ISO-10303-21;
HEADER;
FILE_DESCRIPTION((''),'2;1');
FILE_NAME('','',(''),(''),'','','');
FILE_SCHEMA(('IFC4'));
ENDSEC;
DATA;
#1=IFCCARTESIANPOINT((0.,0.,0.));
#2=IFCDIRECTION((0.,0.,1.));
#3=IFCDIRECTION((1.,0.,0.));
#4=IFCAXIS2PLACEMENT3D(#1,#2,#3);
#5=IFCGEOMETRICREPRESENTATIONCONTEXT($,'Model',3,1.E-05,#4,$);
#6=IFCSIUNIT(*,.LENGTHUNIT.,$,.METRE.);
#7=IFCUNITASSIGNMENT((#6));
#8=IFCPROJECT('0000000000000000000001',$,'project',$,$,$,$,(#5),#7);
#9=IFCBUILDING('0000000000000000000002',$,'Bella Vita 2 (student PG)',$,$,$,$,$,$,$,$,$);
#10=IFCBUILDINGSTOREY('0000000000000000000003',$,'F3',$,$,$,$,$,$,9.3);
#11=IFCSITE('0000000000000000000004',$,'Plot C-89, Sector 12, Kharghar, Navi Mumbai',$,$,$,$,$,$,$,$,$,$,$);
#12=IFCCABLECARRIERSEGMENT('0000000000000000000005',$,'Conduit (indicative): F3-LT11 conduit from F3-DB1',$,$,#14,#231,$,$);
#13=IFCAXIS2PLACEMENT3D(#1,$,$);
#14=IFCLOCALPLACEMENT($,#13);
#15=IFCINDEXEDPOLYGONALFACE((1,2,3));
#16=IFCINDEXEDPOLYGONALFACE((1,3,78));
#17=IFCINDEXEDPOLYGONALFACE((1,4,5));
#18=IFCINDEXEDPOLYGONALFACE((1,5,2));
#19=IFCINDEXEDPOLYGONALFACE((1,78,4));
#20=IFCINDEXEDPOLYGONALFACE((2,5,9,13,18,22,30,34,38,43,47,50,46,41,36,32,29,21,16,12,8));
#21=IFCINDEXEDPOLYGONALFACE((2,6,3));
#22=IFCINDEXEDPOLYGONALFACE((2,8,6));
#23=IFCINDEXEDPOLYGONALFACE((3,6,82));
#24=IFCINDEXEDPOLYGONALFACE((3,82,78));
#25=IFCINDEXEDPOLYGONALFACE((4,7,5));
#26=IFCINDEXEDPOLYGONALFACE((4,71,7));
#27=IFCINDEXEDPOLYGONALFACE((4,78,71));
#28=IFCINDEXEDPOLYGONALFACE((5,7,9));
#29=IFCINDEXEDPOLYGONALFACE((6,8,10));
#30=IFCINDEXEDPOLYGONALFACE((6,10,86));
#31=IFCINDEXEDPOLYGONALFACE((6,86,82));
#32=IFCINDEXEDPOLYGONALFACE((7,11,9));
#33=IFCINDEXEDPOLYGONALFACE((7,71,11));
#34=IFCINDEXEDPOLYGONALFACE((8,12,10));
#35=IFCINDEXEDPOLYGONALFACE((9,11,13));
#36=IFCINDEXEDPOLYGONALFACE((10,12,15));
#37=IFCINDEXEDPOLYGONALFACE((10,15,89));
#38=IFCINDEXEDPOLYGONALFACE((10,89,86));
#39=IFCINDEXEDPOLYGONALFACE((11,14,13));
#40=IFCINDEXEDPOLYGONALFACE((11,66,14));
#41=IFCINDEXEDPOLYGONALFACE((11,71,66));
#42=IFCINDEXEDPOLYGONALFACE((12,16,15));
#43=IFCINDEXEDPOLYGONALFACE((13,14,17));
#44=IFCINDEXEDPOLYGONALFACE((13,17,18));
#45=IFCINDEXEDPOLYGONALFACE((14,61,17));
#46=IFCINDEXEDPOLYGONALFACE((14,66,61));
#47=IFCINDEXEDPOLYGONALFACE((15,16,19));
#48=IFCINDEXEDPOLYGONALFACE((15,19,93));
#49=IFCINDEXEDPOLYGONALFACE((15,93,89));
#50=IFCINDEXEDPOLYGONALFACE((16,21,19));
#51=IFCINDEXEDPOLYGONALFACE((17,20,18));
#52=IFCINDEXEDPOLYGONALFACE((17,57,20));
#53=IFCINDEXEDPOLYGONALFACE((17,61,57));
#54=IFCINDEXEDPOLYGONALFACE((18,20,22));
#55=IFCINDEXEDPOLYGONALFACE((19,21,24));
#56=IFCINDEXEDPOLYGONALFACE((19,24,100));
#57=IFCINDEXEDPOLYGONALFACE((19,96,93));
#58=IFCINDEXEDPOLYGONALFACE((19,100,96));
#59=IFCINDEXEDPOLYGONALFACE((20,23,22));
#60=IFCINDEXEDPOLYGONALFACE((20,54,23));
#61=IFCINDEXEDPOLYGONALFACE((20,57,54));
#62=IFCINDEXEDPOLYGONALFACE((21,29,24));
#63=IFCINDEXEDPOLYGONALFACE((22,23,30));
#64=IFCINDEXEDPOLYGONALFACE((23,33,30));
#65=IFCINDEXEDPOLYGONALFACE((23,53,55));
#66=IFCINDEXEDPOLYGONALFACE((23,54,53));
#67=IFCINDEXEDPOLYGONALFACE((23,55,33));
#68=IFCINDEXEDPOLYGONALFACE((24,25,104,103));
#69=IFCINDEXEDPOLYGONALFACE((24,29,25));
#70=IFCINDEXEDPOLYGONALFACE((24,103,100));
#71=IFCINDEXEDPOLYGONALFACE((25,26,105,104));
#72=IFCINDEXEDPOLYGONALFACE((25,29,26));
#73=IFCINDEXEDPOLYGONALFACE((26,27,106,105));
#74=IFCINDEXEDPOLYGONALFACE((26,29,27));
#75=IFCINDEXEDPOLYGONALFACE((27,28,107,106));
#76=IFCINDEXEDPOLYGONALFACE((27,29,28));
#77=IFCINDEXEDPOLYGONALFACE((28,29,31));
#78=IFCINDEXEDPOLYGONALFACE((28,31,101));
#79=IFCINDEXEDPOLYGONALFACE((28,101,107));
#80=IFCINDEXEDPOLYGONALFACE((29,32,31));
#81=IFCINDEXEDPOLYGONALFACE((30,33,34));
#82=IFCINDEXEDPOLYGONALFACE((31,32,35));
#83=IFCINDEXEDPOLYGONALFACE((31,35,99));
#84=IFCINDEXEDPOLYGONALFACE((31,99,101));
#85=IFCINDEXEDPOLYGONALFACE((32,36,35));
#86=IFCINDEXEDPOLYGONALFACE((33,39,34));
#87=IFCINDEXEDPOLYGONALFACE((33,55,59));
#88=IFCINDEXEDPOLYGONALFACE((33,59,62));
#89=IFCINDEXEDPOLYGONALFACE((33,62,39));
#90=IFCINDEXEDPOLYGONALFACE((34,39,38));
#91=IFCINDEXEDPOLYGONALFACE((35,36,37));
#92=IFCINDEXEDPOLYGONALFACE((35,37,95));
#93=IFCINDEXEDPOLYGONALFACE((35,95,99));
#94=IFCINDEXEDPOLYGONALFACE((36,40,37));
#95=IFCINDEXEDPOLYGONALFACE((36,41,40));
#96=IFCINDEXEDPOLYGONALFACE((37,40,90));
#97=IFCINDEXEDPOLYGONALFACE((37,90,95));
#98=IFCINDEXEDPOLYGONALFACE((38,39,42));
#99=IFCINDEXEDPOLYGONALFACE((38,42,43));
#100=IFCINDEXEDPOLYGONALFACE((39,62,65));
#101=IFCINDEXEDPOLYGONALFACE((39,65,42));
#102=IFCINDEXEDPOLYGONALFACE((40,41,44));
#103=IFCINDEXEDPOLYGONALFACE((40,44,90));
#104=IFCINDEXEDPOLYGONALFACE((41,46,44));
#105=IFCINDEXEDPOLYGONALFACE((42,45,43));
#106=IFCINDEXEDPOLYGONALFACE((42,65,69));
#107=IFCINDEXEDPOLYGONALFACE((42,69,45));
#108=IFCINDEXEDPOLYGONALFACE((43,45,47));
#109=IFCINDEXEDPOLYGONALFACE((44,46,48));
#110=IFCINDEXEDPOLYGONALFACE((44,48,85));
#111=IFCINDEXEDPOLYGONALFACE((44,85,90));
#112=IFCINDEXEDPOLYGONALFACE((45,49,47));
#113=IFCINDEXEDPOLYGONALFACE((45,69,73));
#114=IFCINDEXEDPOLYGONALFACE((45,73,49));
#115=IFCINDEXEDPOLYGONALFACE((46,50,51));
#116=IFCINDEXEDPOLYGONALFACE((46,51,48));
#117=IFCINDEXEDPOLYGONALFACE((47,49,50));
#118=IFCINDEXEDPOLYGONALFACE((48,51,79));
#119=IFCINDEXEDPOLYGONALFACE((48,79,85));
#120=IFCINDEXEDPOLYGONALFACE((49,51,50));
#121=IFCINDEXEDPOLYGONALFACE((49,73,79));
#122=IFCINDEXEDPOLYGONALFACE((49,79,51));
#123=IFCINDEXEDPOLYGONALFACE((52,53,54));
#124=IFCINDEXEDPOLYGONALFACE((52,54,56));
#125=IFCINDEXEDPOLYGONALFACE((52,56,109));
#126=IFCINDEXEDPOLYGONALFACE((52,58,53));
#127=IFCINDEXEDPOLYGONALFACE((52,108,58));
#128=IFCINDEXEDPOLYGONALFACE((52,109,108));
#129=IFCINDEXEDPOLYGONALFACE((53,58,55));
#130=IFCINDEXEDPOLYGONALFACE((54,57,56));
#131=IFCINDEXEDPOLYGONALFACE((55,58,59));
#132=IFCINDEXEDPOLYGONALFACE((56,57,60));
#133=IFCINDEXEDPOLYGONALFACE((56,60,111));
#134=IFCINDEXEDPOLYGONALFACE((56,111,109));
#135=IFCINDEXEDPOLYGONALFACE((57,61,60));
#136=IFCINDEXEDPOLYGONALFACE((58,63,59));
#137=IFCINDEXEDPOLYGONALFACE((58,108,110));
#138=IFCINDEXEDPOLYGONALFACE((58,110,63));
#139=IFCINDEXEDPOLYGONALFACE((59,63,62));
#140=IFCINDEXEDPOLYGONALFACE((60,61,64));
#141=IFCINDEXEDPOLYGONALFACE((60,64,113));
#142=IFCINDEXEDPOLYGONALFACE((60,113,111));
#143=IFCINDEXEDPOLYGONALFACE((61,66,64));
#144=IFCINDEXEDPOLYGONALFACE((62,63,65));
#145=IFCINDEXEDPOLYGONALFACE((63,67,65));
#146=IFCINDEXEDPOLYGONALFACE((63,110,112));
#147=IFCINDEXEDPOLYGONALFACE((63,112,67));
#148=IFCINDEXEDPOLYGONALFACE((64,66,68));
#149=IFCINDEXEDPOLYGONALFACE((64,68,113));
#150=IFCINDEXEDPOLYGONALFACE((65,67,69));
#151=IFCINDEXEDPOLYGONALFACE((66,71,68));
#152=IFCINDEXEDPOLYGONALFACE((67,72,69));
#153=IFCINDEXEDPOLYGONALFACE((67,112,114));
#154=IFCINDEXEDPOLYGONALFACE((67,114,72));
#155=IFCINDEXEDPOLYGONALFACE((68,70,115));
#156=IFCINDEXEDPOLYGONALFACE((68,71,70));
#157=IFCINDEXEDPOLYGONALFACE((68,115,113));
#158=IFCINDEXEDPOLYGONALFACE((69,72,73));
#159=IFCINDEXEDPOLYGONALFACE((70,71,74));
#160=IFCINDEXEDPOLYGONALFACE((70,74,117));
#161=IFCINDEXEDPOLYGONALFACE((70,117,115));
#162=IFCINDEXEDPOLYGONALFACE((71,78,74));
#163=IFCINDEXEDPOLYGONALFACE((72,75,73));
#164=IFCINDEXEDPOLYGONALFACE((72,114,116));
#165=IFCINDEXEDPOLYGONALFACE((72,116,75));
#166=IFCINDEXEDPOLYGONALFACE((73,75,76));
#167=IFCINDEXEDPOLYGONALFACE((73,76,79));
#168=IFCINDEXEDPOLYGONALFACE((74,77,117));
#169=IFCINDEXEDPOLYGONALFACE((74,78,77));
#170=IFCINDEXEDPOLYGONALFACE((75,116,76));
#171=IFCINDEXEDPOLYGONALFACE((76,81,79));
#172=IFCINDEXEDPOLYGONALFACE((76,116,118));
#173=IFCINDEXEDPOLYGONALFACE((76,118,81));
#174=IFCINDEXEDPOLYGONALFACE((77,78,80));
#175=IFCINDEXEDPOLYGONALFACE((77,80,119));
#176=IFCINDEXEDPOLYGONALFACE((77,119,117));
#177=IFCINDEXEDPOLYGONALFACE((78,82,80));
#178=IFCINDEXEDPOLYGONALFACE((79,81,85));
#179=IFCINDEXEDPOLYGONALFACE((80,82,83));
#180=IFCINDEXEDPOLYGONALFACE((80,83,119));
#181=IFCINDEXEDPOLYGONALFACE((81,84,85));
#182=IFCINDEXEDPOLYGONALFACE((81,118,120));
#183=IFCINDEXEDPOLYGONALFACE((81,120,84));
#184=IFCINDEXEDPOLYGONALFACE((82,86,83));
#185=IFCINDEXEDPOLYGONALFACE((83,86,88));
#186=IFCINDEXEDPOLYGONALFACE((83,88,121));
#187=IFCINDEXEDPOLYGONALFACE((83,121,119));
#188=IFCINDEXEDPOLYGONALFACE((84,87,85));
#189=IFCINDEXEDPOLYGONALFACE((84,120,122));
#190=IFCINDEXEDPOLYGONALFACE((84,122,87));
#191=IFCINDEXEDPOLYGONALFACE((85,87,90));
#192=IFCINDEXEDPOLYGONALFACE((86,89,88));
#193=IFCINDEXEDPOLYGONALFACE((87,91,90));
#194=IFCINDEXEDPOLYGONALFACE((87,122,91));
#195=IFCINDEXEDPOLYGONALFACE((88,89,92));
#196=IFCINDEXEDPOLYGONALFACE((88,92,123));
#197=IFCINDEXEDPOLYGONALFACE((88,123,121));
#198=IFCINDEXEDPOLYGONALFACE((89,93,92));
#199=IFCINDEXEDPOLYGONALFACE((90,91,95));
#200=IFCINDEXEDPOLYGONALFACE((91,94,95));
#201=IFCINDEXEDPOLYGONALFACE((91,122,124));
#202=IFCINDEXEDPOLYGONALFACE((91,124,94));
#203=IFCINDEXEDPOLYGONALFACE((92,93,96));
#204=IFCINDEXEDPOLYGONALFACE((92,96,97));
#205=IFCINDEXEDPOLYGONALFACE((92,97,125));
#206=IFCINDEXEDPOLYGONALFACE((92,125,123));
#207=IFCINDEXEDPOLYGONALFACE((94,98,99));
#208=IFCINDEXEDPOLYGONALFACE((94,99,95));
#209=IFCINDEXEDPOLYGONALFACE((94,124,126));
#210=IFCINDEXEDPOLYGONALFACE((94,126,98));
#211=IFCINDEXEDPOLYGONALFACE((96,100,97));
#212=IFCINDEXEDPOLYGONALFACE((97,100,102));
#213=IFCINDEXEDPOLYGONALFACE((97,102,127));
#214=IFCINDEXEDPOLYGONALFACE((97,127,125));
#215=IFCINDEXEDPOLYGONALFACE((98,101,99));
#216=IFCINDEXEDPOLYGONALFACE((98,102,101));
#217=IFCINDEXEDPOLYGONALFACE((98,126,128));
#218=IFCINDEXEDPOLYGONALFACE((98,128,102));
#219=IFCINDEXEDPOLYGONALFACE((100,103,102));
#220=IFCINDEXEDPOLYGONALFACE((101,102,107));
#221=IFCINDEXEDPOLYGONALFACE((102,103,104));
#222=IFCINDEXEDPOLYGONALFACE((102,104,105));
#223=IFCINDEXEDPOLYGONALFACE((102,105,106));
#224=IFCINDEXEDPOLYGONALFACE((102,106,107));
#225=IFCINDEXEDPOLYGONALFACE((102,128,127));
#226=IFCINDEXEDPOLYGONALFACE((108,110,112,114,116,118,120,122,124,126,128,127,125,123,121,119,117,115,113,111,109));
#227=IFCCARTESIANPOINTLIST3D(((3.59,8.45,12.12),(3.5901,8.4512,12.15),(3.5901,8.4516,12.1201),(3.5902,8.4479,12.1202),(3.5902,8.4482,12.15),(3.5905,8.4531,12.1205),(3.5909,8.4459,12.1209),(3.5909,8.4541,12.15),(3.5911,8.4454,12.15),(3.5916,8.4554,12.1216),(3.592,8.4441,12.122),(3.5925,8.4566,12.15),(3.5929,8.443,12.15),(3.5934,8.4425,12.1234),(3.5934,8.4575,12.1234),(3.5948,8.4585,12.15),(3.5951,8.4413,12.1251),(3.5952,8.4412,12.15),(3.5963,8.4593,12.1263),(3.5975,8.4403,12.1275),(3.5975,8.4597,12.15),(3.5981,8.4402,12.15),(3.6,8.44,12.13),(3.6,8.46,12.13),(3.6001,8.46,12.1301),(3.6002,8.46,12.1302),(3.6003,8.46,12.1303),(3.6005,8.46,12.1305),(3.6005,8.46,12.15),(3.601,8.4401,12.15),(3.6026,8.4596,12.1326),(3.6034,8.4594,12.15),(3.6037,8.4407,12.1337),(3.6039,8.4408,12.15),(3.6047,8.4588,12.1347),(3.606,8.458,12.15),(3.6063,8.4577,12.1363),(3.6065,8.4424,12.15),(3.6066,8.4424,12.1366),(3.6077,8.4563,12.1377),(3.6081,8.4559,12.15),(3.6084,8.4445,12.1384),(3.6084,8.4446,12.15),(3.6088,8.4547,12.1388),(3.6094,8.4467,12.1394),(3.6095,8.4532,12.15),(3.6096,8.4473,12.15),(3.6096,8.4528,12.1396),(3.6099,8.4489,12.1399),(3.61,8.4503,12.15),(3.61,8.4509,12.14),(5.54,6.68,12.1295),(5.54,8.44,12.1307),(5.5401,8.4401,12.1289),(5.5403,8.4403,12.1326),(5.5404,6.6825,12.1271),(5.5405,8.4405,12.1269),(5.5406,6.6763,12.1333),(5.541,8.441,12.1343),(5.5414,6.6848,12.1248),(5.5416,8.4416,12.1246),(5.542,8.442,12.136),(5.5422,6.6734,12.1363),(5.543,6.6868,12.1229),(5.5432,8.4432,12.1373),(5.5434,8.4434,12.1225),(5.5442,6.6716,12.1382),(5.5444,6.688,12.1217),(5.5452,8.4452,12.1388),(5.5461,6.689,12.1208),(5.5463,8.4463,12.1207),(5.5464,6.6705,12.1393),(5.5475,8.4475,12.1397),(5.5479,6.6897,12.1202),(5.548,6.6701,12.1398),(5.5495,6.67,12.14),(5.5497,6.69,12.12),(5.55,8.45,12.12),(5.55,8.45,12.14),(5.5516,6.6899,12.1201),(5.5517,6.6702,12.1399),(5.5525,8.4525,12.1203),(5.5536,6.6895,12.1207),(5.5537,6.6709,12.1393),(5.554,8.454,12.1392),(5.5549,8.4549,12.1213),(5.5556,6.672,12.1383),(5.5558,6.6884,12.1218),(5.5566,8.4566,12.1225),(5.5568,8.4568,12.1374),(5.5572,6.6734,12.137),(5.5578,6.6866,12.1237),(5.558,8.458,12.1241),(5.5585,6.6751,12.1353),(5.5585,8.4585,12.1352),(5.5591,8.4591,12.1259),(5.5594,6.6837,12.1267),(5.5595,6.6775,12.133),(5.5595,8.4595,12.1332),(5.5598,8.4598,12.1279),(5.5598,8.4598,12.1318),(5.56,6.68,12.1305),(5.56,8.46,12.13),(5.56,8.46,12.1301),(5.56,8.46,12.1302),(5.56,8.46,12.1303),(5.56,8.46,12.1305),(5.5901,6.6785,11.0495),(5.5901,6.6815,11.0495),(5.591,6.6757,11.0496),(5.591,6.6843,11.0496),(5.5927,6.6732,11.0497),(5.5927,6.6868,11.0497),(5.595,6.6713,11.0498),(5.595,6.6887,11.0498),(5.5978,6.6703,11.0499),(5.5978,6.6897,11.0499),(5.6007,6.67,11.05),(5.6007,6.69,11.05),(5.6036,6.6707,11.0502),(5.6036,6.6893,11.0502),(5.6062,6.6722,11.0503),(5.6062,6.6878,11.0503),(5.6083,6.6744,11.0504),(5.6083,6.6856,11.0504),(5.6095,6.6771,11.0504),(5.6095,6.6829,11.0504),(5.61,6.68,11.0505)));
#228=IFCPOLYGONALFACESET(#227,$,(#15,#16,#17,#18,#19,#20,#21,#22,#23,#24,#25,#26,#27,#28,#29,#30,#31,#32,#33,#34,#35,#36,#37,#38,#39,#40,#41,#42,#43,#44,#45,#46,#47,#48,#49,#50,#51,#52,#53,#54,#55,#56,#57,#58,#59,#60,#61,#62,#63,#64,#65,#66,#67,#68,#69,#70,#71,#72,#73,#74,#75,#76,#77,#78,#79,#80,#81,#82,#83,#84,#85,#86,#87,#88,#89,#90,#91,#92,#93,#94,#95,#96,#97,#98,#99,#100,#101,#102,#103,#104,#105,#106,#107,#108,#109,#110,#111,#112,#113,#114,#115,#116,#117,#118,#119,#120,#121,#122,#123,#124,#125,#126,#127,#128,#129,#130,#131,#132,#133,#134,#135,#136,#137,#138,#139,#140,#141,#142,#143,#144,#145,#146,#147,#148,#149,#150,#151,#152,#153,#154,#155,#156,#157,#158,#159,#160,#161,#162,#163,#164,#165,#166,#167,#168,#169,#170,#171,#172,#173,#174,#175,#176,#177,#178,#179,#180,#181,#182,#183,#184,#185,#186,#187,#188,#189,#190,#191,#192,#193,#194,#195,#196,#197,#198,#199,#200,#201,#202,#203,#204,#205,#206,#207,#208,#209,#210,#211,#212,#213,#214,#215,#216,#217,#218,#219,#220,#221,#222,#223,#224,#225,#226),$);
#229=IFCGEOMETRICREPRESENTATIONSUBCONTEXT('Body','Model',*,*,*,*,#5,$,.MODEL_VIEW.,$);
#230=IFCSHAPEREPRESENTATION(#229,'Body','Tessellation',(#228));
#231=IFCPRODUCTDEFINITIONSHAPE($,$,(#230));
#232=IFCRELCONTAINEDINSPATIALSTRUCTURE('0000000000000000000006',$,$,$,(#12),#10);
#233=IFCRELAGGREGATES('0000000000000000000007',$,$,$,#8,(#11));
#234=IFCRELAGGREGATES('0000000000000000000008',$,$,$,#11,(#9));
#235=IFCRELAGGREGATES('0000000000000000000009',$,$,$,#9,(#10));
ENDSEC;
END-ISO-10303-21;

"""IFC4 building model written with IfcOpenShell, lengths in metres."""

from ifc_helpers import new_model, entity, si_unit, origin, origin_with_axes, place, context, subcontext, project, spatial, element, save


model = new_model("IFC4")

# Units and contexts
model_context = context("Model", 3, precision=1e-05, world=origin_with_axes())
body_context = subcontext(model_context, "Body", "Model", "MODEL_VIEW")
ifc_project = project(units=[si_unit("LENGTHUNIT", "METRE")], contexts=[model_context])

# Site, building, storey
site = spatial("IfcSite", under=ifc_project, Name="Plot C-89, Sector 12, Kharghar, Navi Mumbai")
building = spatial("IfcBuilding", under=site, Name="Bella Vita 2 (student PG)")
storey = spatial("IfcBuildingStorey", under=building, Name="F3", Elevation=9.3)

# Cable carrier segment
cable_carrier_segment_1_placement = place(None, origin())
element("IfcCableCarrierSegment", 1, at=cable_carrier_segment_1_placement, inside=storey, Name="Conduit (indicative): F3-LT11 conduit from F3-DB1", context=body_context, shape_type="AdvancedSweptSolid", body=[
    entity("IfcSweptDiskSolid", entity("IfcPolyline", [entity("IfcCartesianPoint", [5.6, 6.68, 11.05]), entity("IfcCartesianPoint", [5.55, 6.68, 12.13]), entity("IfcCartesianPoint", [5.55, 8.45, 12.13]), entity("IfcCartesianPoint", [3.6, 8.45, 12.13]), entity("IfcCartesianPoint", [3.6, 8.45, 12.15])]), 0.01),
])

save(model, "model.ifc")
